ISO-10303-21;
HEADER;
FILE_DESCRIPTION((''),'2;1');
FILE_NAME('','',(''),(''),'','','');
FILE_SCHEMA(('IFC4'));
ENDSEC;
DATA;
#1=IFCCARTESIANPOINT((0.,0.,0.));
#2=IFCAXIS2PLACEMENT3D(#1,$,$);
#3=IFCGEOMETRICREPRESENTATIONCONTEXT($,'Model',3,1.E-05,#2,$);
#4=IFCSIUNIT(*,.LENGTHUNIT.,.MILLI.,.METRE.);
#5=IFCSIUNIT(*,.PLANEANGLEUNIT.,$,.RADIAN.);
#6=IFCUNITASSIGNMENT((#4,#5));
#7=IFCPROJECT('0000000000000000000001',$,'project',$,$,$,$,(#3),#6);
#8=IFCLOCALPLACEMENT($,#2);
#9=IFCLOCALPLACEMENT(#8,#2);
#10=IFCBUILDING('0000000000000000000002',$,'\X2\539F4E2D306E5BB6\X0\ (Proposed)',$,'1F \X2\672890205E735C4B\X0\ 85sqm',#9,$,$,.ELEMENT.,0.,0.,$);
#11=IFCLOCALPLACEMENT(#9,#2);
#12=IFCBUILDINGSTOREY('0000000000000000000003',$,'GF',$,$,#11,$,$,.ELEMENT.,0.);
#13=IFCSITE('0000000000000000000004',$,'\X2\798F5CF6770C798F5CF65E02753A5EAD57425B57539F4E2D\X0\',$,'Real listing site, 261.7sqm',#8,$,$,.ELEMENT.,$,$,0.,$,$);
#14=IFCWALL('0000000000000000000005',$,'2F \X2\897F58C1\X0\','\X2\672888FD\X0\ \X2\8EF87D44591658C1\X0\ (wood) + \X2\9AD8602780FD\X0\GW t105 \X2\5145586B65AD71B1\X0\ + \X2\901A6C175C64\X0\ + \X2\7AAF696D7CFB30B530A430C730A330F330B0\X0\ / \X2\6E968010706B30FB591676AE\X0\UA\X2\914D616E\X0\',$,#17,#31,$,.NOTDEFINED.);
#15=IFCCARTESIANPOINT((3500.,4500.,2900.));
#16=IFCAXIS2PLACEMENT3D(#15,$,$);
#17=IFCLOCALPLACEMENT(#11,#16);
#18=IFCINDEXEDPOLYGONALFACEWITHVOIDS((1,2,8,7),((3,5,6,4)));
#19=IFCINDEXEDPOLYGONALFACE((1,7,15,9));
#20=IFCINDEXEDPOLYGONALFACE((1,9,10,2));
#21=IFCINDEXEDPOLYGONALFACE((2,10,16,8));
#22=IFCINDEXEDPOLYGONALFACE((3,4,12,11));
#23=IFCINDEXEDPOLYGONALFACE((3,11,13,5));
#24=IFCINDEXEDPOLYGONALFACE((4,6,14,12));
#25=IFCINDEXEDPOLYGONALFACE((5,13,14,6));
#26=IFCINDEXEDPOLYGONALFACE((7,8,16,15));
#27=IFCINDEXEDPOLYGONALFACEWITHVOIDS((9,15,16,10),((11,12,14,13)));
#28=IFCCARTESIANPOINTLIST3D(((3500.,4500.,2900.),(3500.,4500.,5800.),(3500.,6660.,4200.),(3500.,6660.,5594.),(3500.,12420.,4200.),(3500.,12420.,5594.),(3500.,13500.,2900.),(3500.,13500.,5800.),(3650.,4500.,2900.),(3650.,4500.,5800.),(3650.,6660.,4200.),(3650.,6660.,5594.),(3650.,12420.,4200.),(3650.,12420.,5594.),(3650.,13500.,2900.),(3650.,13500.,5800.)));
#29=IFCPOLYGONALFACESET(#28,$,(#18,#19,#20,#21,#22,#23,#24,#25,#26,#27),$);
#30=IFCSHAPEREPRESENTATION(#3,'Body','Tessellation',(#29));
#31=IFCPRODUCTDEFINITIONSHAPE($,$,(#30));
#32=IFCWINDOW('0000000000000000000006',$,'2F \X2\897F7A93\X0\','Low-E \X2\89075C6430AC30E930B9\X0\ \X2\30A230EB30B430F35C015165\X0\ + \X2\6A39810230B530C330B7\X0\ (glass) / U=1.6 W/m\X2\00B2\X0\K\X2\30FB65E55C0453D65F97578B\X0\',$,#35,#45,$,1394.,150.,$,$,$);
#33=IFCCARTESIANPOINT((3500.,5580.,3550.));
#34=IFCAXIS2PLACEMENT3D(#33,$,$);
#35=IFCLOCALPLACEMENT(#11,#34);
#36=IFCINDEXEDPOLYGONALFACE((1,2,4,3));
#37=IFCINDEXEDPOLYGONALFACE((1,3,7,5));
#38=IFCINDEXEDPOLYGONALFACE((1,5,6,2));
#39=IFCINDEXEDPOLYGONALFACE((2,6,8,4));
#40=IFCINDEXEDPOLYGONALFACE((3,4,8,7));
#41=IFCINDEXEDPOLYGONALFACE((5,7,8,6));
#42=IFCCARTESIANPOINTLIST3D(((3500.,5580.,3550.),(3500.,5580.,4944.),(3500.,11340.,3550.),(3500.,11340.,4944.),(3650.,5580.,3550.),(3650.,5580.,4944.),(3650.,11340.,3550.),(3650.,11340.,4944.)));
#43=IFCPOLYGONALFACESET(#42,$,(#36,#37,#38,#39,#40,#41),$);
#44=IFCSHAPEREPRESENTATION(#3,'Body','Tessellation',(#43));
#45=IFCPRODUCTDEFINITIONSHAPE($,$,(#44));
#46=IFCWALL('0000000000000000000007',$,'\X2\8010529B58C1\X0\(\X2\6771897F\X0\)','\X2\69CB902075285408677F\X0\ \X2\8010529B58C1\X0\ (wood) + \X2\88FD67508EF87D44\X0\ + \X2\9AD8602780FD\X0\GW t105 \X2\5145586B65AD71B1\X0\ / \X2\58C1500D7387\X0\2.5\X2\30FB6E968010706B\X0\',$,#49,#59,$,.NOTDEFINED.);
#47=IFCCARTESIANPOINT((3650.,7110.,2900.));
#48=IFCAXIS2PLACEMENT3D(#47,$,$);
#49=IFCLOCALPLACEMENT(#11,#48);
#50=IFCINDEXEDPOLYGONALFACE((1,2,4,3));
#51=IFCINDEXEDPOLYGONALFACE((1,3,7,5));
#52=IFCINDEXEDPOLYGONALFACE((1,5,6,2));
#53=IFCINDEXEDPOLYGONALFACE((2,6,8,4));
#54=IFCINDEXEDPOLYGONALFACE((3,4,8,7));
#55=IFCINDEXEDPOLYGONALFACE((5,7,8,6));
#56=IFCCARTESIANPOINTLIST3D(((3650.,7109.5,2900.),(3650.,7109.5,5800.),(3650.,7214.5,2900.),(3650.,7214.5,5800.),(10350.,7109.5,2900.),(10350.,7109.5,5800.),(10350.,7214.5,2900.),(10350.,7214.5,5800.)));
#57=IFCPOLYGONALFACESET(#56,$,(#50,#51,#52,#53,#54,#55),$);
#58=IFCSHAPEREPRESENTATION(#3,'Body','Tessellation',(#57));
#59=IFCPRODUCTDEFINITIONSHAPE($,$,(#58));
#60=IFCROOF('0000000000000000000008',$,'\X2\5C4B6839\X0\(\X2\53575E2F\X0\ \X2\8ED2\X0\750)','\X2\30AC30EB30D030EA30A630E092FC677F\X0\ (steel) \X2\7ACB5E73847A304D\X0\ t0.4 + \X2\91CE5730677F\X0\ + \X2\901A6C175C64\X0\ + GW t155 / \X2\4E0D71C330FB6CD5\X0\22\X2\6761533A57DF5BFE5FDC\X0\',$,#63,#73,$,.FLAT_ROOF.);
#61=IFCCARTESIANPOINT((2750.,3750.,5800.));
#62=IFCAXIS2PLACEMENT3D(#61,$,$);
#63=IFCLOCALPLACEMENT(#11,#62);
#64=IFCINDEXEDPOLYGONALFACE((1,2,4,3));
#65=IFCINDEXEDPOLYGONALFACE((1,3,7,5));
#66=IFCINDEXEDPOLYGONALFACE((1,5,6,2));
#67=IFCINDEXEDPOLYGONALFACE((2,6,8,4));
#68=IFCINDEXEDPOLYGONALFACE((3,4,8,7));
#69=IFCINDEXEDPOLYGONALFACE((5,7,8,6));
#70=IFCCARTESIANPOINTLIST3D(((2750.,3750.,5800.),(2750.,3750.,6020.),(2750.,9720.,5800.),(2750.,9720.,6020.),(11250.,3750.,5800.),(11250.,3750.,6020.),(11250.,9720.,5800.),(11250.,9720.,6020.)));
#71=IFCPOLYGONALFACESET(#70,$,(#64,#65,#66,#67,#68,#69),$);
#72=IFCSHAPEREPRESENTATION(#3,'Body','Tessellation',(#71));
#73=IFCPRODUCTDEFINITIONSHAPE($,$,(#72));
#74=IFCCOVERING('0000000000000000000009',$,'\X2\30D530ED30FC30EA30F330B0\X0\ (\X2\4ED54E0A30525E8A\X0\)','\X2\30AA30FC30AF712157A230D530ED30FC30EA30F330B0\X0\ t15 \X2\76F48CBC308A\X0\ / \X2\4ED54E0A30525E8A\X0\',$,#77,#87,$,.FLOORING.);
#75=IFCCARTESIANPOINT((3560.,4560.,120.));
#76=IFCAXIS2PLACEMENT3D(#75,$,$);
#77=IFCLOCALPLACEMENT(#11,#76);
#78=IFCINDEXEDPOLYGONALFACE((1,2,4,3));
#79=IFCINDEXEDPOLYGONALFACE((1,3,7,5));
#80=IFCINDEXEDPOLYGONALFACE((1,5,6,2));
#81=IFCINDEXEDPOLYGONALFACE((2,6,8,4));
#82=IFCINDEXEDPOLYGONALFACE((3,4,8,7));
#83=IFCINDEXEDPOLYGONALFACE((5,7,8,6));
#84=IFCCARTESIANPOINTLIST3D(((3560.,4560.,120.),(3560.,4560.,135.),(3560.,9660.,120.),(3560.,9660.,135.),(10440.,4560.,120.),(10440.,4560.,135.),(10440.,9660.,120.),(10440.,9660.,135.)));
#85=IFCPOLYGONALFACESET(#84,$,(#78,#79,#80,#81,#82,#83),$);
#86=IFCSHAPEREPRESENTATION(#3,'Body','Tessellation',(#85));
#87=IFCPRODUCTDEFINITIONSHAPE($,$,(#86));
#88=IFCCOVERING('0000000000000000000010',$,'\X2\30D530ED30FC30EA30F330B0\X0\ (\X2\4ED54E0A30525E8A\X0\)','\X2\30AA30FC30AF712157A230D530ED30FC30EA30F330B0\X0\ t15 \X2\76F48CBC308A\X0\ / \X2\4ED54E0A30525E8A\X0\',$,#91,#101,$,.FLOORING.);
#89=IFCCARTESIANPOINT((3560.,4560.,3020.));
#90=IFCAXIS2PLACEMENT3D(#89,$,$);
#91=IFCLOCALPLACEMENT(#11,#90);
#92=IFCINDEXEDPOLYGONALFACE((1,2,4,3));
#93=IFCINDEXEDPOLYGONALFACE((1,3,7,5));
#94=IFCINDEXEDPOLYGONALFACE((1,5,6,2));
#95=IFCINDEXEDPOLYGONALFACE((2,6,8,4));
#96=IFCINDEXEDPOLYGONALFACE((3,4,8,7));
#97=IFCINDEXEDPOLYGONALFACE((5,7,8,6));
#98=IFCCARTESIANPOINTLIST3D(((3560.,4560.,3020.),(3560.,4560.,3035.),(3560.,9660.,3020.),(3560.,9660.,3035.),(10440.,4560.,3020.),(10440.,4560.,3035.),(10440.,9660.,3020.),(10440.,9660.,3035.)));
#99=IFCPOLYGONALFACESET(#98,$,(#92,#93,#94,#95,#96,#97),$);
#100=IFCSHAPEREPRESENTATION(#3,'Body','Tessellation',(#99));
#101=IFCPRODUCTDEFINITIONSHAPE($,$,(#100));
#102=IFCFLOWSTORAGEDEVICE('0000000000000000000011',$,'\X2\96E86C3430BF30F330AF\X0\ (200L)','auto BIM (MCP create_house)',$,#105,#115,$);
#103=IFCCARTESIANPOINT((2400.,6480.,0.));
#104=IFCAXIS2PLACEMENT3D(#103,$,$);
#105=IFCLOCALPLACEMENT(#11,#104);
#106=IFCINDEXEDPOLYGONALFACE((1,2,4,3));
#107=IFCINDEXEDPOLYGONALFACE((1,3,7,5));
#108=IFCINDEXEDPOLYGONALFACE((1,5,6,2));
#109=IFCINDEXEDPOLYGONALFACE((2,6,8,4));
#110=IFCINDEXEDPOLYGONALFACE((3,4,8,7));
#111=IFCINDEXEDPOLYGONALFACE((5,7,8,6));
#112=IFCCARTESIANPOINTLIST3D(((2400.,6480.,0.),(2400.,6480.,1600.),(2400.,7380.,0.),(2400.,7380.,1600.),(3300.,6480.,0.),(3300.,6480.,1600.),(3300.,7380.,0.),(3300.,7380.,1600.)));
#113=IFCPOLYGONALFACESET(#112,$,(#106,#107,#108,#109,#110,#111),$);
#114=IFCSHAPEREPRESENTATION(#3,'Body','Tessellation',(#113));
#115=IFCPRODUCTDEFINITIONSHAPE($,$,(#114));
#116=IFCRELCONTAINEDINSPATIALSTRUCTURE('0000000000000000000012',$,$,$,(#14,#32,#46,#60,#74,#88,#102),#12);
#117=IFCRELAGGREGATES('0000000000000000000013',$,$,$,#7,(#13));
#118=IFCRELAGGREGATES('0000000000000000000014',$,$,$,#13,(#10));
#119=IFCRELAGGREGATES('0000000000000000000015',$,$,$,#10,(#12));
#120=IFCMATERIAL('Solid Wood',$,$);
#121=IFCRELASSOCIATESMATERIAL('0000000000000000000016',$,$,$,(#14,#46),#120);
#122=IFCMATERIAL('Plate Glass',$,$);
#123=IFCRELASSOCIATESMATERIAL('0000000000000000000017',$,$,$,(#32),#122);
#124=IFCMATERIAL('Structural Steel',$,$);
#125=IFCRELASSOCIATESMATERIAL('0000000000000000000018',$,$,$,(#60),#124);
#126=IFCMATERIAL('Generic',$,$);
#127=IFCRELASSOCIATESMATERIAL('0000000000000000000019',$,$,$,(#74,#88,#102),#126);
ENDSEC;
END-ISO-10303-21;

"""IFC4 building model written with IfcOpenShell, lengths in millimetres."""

from ifc_helpers import new_model, si_unit, frame, frame_2d, origin, place, context, project, spatial, rectangle, extrude, material, element, fill, save


model = new_model("IFC4")

# Units and contexts
model_context = context("Model", 3, precision=1e-05, world=origin())
ifc_project = project(units=[si_unit("LENGTHUNIT", "METRE", prefix="MILLI"), si_unit("PLANEANGLEUNIT", "RADIAN")], contexts=[model_context])

# Site, building, storey
site_placement = place(None, origin())
site = spatial("IfcSite", under=ifc_project, at=site_placement, Name="福島県福島市町庭坂字原中", ObjectType="Real listing site, 261.7sqm", CompositionType="ELEMENT", RefElevation=0.0)
building_placement = place(site_placement, origin())
building = spatial("IfcBuilding", under=site, at=building_placement, Name="原中の家 (Proposed)", ObjectType="1F 木造平屋 85sqm", CompositionType="ELEMENT", ElevationOfRefHeight=0.0, ElevationOfTerrain=0.0)
storey_placement = place(building_placement, origin())
storey = spatial("IfcBuildingStorey", under=building, at=storey_placement, Name="GF", CompositionType="ELEMENT", Elevation=0.0)

# Shared definitions
ifc_material_1 = material(Name="Solid Wood")
ifc_material_2 = material(Name="Generic")

# Shared definitions
ifc_material_3 = material(Name="Plate Glass")

# Wall, opening, window
wall_1_placement = place(storey_placement, frame((3500.0, 4500.0, 2900.0)))
wall_1 = element("IfcWall", 1, at=wall_1_placement, inside=storey, material=ifc_material_1, Name="2F 西壁", Description="木製 軸組外壁 (wood) + 高性能GW t105 充填断熱 + 通気層 + 窯業系サイディング / 準耐火・外皮UA配慮", PredefinedType="NOTDEFINED", context=model_context, shape_type="SweptSolid", body=[
    extrude(rectangle(XDim=150.0, YDim=9000.0, at=frame_2d((75.0, 4500.0))), frame((3500.0, 4500.0, 2900.0)), (0.0, 0.0, 1.0), 2900.0),
])
opening_1_placement = place(storey_placement, frame((3500.0, 5580.0, 3550.0)))
opening_1 = element("IfcOpeningElement", 2, at=opening_1_placement, cuts=wall_1, PredefinedType="NOTDEFINED", context=model_context, shape_type="SweptSolid", body=[
    extrude(rectangle(XDim=150.0, YDim=5760.0, at=frame_2d((75.0, 2880.0))), frame((3500.0, 5580.0, 3550.0)), (0.0, 0.0, 1.0), 1394.0),
])
window_1_placement = place(storey_placement, frame((3500.0, 5580.0, 3550.0)))
window_1 = element("IfcWindow", 3, at=window_1_placement, inside=storey, material=ifc_material_3, Name="2F 西窓", Description="Low-E 複層ガラス アルゴン封入 + 樹脂サッシ (glass) / U=1.6 W/m²K・日射取得型", OverallHeight=1394.0, OverallWidth=150.0, context=model_context, shape_type="SweptSolid", body=[
    extrude(rectangle(XDim=150.0, YDim=5760.0, at=frame_2d((75.0, 2880.0))), frame((3500.0, 5580.0, 3550.0)), (0.0, 0.0, 1.0), 1394.0),
])
fill(opening_1, window_1)

# Wall
wall_2_placement = place(storey_placement, frame((3650.0, 7110.0, 2900.0)))
element("IfcWall", 4, at=wall_2_placement, inside=storey, material=ifc_material_1, Name="耐力壁(東西)", Description="構造用合板 耐力壁 (wood) + 製材軸組 + 高性能GW t105 充填断熱 / 壁倍率2.5・準耐火", PredefinedType="NOTDEFINED", context=model_context, shape_type="SweptSolid", body=[
    extrude(rectangle(XDim=6700.0, YDim=105.0, at=frame_2d((3350.0, 52.0))), frame((3650.0, 7110.0, 2900.0)), (0.0, 0.0, 1.0), 2900.0),
])

# Roof
ifc_material_4 = material(Name="Structural Steel")
for number, where, name in (
    (5, (2750.0, 3750.0, 5800.0), "屋根(南帯 軒750)"),
):
    element("IfcRoof", number, at=place(storey_placement, frame(where)), inside=storey, material=ifc_material_4, Name=name, Description="ガルバリウム鋼板 (steel) 立平葺き t0.4 + 野地板 + 通気層 + GW t155 / 不燃・法22条区域対応", PredefinedType="FLAT_ROOF", context=model_context, shape_type="SweptSolid", body=[
        extrude(rectangle(XDim=8500.0, YDim=5970.0, at=frame_2d((4250.0, 2985.0))), frame((2750.0, 3750.0, 5800.0)), (0.0, 0.0, 1.0), 220.0),
    ])

# Coverings
covering_1_placement = place(storey_placement, frame((3560.0, 4560.0, 120.0)))
element("IfcCovering", 6, at=covering_1_placement, inside=storey, material=ifc_material_2, Name="フローリング (仕上げ床)", Description="オーク無垢フローリング t15 直貼り / 仕上げ床", PredefinedType="FLOORING", context=model_context, shape_type="SweptSolid", body=[
    extrude(rectangle(XDim=6880.0, YDim=5100.0, at=frame_2d((3440.0, 2550.0))), frame((3560.0, 4560.0, 120.0)), (0.0, 0.0, 1.0), 15.0),
])
covering_2_placement = place(storey_placement, frame((3560.0, 4560.0, 3020.0)))
element("IfcCovering", 7, at=covering_2_placement, inside=storey, material=ifc_material_2, Name="フローリング (仕上げ床)", Description="オーク無垢フローリング t15 直貼り / 仕上げ床", PredefinedType="FLOORING", context=model_context, shape_type="SweptSolid", body=[
    extrude(rectangle(XDim=6880.0, YDim=5100.0, at=frame_2d((3440.0, 2550.0))), frame((3560.0, 4560.0, 3020.0)), (0.0, 0.0, 1.0), 15.0),
])

# Flow storage device
flow_storage_device_placement = place(storey_placement, frame((2400.0, 6480.0, 0.0)))
element("IfcFlowStorageDevice", 8, at=flow_storage_device_placement, inside=storey, material=ifc_material_2, Name="雨水タンク (200L)", Description="auto BIM (MCP create_house)", context=model_context, shape_type="SweptSolid", body=[
    extrude(rectangle(XDim=900.0, YDim=900.0, at=frame_2d((450.0, 450.0))), frame((2400.0, 6480.0, 0.0)), (0.0, 0.0, 1.0), 1600.0),
])

save(model, "model.ifc")
